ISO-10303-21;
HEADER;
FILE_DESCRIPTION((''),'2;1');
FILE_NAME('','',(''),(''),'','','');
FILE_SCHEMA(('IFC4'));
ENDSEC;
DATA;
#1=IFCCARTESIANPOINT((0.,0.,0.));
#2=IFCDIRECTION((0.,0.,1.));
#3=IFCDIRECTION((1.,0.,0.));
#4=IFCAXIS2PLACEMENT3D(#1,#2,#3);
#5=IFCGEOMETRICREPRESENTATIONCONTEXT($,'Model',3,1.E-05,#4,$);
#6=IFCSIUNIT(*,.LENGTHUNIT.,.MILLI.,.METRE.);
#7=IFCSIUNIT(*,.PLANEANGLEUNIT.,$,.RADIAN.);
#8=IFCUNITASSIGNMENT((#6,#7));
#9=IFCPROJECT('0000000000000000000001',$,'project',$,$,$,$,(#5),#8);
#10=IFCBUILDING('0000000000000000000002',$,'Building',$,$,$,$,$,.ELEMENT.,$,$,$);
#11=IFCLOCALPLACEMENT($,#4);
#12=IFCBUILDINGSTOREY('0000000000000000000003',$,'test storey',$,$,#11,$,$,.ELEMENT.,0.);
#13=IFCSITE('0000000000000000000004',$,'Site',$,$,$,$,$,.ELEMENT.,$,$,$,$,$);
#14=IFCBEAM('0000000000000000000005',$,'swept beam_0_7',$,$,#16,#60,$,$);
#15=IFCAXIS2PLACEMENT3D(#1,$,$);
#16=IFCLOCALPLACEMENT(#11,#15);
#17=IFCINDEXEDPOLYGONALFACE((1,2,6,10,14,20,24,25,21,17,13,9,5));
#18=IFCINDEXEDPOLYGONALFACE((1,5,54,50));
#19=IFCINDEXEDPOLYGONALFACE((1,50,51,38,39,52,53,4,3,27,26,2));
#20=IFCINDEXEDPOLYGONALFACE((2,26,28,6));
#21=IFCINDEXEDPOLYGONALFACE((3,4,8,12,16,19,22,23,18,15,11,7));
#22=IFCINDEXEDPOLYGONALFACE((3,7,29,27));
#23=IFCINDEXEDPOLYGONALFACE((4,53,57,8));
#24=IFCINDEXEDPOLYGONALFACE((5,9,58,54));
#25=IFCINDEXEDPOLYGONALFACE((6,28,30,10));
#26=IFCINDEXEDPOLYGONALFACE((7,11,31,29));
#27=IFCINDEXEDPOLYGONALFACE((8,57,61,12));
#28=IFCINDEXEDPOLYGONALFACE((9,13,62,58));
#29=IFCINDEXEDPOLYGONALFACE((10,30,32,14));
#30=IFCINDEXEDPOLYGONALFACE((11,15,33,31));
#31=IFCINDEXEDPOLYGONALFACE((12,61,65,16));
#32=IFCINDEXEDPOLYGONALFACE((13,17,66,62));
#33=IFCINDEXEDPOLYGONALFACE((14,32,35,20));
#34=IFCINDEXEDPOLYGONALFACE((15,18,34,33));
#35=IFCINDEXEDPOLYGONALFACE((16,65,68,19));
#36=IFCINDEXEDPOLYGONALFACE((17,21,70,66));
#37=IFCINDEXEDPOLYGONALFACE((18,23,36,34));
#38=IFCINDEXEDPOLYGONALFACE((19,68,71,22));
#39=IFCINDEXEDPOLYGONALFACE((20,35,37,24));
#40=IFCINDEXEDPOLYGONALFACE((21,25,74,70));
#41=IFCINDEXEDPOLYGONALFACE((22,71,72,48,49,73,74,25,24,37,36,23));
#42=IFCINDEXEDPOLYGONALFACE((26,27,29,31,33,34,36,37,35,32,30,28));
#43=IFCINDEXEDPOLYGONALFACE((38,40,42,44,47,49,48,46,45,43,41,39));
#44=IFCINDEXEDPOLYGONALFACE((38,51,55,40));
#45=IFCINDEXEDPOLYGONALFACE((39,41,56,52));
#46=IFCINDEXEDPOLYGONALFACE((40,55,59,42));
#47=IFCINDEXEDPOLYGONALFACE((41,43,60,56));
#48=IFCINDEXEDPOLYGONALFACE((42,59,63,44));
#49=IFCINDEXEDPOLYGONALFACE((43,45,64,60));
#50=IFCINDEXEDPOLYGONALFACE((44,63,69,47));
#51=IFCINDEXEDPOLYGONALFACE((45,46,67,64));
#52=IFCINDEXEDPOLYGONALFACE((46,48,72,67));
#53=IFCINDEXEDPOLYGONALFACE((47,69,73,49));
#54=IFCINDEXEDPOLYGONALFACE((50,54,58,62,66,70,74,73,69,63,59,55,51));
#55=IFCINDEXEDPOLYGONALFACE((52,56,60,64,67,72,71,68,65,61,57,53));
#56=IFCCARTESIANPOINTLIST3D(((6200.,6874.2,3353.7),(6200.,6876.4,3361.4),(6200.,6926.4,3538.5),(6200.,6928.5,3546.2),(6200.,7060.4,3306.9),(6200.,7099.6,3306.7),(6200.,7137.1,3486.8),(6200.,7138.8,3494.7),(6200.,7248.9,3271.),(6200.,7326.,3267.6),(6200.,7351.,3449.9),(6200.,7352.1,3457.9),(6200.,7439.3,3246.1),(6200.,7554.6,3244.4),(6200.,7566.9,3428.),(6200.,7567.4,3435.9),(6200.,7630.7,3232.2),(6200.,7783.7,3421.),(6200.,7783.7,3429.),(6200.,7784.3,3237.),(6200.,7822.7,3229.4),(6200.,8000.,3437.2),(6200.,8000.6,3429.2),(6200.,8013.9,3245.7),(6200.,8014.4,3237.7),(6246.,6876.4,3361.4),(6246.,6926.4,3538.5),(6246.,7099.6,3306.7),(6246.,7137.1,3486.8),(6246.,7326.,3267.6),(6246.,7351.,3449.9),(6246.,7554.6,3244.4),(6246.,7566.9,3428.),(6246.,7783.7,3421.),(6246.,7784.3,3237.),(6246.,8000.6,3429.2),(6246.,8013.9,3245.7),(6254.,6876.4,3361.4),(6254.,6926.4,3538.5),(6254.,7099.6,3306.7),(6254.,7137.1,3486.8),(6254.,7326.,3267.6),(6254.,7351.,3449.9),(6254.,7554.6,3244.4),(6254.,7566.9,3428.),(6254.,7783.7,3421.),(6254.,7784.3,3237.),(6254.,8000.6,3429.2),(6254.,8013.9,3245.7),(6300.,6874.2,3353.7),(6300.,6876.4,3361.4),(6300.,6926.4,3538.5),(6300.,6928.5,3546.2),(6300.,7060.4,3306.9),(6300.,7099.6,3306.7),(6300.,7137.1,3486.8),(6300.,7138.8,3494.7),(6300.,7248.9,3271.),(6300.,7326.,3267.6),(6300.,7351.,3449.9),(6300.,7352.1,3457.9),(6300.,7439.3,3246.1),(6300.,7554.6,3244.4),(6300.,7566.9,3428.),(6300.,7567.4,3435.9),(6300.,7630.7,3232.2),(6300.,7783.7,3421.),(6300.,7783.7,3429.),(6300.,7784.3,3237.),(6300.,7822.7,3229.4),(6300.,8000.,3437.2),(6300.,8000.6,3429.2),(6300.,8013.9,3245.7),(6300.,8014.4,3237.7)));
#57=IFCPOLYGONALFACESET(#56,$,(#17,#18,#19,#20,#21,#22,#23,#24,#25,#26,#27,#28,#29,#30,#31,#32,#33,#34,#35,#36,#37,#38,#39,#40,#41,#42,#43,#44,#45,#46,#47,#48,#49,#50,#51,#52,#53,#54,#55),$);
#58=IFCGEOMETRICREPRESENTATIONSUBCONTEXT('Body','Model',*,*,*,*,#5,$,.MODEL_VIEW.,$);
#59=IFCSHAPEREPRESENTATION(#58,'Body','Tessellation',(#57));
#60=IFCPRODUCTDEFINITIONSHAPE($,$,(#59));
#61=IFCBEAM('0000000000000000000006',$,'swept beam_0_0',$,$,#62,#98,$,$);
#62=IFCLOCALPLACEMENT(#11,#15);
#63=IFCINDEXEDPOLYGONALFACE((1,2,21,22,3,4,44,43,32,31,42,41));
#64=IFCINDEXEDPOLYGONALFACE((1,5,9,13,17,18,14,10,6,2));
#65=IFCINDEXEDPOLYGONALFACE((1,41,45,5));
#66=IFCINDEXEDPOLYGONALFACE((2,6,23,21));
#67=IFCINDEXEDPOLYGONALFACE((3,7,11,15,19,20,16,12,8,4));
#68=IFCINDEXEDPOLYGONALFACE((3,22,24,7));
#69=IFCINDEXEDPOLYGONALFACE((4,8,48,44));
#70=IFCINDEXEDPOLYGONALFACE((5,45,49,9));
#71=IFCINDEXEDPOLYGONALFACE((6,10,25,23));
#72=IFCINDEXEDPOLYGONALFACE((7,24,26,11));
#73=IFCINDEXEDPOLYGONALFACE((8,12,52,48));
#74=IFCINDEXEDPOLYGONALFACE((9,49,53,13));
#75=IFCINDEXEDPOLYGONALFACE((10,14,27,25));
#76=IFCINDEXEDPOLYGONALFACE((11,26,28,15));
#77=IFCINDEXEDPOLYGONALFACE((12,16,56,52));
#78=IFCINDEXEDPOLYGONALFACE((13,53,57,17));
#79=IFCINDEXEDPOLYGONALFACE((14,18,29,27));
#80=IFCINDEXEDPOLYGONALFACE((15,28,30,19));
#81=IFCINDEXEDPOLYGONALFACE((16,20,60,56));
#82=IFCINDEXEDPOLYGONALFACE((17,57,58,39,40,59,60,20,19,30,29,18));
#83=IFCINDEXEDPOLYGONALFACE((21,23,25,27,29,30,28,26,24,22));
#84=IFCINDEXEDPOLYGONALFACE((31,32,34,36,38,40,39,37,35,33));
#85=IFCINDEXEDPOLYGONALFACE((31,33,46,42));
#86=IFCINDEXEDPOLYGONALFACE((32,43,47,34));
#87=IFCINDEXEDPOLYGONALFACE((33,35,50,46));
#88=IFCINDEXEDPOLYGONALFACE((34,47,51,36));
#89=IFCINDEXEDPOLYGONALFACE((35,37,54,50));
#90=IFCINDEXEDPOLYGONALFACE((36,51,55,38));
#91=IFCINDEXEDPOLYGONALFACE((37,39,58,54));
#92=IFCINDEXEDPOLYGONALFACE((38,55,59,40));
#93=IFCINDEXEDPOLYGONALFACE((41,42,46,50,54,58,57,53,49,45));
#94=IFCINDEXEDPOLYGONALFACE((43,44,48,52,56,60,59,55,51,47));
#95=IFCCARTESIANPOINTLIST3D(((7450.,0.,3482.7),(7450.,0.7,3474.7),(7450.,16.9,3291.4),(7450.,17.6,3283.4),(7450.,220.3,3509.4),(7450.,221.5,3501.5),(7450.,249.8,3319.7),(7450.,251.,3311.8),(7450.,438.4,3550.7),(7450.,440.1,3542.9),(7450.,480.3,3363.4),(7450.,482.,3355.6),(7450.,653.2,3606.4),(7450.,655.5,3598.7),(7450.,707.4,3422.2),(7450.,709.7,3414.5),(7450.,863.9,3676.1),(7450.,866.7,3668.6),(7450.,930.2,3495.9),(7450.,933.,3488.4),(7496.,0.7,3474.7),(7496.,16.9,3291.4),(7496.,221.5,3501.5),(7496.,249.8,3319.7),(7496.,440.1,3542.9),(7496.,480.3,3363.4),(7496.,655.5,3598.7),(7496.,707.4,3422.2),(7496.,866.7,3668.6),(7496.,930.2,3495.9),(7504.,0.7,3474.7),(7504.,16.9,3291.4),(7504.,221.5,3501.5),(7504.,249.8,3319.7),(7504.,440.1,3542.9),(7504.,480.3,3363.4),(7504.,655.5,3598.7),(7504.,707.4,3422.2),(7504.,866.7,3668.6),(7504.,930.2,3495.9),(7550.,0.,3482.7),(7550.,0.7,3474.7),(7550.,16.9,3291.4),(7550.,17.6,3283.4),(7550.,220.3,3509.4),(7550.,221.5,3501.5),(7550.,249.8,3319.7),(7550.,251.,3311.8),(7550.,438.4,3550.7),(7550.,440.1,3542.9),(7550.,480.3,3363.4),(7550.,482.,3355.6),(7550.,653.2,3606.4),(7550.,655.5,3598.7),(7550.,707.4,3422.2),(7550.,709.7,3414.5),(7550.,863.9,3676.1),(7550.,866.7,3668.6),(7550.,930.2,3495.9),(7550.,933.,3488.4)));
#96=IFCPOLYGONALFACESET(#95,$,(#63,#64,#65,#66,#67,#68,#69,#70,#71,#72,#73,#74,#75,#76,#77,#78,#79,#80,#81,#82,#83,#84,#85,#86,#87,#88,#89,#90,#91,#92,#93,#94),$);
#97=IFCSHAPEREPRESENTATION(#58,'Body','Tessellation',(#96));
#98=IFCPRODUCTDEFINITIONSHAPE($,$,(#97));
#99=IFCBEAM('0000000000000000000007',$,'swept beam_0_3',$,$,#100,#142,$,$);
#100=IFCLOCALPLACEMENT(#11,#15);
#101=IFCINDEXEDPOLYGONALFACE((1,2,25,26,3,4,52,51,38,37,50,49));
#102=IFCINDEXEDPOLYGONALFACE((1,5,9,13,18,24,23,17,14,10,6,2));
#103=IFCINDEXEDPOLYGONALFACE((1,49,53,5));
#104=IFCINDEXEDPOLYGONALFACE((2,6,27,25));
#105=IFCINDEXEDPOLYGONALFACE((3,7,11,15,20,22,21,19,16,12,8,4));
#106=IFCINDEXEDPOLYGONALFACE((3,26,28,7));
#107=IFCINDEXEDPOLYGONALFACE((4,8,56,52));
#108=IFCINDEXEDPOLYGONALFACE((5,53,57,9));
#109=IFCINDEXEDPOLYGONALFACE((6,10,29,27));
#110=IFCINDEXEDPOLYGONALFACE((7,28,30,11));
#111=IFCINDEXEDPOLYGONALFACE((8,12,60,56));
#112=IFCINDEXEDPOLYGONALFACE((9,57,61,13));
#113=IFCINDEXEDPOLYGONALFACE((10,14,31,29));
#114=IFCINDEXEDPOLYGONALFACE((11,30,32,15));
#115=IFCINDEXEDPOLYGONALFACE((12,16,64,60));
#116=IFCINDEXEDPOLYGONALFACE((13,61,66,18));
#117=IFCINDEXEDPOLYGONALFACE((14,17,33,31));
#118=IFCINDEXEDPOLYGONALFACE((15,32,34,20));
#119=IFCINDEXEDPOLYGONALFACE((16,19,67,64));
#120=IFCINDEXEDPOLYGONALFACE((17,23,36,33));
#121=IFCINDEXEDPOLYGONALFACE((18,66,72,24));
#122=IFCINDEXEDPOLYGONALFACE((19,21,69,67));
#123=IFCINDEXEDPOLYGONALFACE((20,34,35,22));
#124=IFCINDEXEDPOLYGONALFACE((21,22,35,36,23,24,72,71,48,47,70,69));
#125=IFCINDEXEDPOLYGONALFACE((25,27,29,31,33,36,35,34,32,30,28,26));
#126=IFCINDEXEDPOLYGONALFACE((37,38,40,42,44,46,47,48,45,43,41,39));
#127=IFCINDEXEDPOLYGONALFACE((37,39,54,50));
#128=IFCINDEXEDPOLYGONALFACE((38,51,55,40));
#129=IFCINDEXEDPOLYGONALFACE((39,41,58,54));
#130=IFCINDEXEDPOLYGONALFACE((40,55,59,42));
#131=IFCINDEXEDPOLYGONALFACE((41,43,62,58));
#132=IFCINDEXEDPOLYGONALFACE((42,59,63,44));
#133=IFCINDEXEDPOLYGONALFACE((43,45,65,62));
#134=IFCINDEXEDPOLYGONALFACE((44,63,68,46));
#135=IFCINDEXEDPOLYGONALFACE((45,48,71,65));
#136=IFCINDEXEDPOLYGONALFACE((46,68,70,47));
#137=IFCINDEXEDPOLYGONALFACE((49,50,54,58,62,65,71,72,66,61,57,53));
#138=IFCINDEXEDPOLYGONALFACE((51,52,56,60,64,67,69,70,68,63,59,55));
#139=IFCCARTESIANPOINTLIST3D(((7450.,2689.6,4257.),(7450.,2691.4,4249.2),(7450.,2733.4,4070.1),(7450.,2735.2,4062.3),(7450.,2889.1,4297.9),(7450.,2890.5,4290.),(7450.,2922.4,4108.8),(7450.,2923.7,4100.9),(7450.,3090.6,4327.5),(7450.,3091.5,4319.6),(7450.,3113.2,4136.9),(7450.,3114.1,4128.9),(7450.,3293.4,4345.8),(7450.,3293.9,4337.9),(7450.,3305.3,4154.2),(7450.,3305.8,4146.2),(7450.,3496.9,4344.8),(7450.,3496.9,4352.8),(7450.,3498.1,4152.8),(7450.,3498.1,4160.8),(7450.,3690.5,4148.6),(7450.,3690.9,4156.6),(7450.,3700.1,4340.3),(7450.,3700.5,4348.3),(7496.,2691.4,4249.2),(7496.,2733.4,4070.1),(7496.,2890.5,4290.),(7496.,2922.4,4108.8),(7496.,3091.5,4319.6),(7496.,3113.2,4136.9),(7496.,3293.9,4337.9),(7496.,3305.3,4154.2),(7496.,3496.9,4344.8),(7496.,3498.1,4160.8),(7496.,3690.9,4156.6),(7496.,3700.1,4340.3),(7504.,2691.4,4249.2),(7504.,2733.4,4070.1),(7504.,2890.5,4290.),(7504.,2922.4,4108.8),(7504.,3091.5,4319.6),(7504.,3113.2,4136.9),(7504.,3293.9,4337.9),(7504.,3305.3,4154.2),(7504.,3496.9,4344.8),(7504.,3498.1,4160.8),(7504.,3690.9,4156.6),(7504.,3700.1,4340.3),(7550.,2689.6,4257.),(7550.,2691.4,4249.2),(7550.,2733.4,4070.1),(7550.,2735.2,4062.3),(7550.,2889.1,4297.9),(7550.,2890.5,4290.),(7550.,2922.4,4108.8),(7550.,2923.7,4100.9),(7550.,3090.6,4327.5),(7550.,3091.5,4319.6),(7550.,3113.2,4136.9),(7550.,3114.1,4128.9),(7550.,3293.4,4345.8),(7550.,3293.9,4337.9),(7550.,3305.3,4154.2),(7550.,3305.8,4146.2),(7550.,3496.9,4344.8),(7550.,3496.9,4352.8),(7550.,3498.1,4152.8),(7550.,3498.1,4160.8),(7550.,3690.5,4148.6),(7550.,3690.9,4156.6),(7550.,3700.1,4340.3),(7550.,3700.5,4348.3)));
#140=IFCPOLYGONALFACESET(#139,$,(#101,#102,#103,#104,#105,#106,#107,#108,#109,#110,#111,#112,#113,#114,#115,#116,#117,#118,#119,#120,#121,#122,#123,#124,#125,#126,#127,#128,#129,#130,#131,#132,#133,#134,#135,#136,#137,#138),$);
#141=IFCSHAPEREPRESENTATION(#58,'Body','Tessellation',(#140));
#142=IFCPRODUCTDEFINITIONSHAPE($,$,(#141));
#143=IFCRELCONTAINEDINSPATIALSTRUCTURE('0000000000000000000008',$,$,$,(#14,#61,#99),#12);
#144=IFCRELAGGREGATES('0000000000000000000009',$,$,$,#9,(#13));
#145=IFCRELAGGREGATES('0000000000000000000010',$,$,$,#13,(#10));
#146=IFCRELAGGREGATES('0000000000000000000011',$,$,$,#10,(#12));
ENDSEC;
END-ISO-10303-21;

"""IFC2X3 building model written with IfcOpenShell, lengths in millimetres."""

from ifc_helpers import new_model, entity, si_unit, origin_with_axes, place, context, subcontext, project, spatial, element, save


model = new_model("IFC2X3")

# Units and contexts
model_context = context("Model", 3, precision=1e-05, world=origin_with_axes())
body_context = subcontext(model_context, "Body", "Model", "MODEL_VIEW")
ifc_project = project(units=[si_unit("LENGTHUNIT", "METRE", prefix="MILLI"), si_unit("PLANEANGLEUNIT", "RADIAN")], contexts=[model_context])

# Site, building, storey
site = spatial("IfcSite", under=ifc_project, Name="Site", CompositionType="ELEMENT")
building = spatial("IfcBuilding", under=site, Name="Building", CompositionType="ELEMENT")
storey_placement = place(None, origin_with_axes())
storey = spatial("IfcBuildingStorey", under=building, at=storey_placement, Name="test storey", CompositionType="ELEMENT", Elevation=0.0)

# Beams
beam_1_placement = place(storey_placement, origin_with_axes())
element("IfcBeam", 1, at=beam_1_placement, inside=storey, Name="swept beam_0_7", context=body_context, shape_type="SweptSolid", body=[
    entity("IfcRevolvedAreaSolid", entity("IfcArbitraryClosedProfileDef", "AREA", None, entity("IfcPolyline", [entity("IfcCartesianPoint", [192.0, 50.0]), entity("IfcCartesianPoint", [192.0, 4.0]), entity("IfcCartesianPoint", [8.0, 4.0]), entity("IfcCartesianPoint", [8.0, 50.0]), entity("IfcCartesianPoint", [0.0, 50.0]), entity("IfcCartesianPoint", [0.0, -50.0]), entity("IfcCartesianPoint", [8.0, -50.0]), entity("IfcCartesianPoint", [8.0, -4.0]), entity("IfcCartesianPoint", [192.0, -4.0]), entity("IfcCartesianPoint", [192.0, -50.0]), entity("IfcCartesianPoint", [200.0, -50.0]), entity("IfcCartesianPoint", [200.0, 50.0]), entity("IfcCartesianPoint", [192.0, 50.0])])), entity("IfcAxis2Placement3D", entity("IfcCartesianPoint", [6250.0, 6928.5, 3546.2]), entity("IfcDirection", [0.0, -0.9624, 0.2717]), entity("IfcDirection", [0.0, -0.2717, -0.9624])), entity("IfcAxis1Placement", entity("IfcCartesianPoint", [-3115.5, 0.0, 0.0]), entity("IfcDirection", [0.0, 1.0, 0.0])), 0.347435),
])
beam_2_placement = place(storey_placement, origin_with_axes())
element("IfcBeam", 2, at=beam_2_placement, inside=storey, Name="swept beam_0_0", context=body_context, shape_type="SweptSolid", body=[
    entity("IfcRevolvedAreaSolid", entity("IfcArbitraryClosedProfileDef", "AREA", None, entity("IfcPolyline", [entity("IfcCartesianPoint", [192.0, 50.0]), entity("IfcCartesianPoint", [192.0, 4.0]), entity("IfcCartesianPoint", [8.0, 4.0]), entity("IfcCartesianPoint", [8.0, 50.0]), entity("IfcCartesianPoint", [0.0, 50.0]), entity("IfcCartesianPoint", [0.0, -50.0]), entity("IfcCartesianPoint", [8.0, -50.0]), entity("IfcCartesianPoint", [8.0, -4.0]), entity("IfcCartesianPoint", [192.0, -4.0]), entity("IfcCartesianPoint", [192.0, -50.0]), entity("IfcCartesianPoint", [200.0, -50.0]), entity("IfcCartesianPoint", [200.0, 50.0]), entity("IfcCartesianPoint", [192.0, 50.0])])), entity("IfcAxis2Placement3D", entity("IfcCartesianPoint", [7500.0, 0.0, 3482.7]), entity("IfcDirection", [0.0, -0.9961, -0.0878]), entity("IfcDirection", [0.0, 0.0878, -0.9961])), entity("IfcAxis1Placement", entity("IfcCartesianPoint", [-3354.7, 0.0, 0.0]), entity("IfcDirection", [0.0, 1.0, 0.0])), 0.264664),
])
beam_3_placement = place(storey_placement, origin_with_axes())
element("IfcBeam", 3, at=beam_3_placement, inside=storey, Name="swept beam_0_3", context=body_context, shape_type="SweptSolid", body=[
    entity("IfcRevolvedAreaSolid", entity("IfcArbitraryClosedProfileDef", "AREA", None, entity("IfcPolyline", [entity("IfcCartesianPoint", [-192.0, -50.0]), entity("IfcCartesianPoint", [-192.0, -4.0]), entity("IfcCartesianPoint", [-8.0, -4.0]), entity("IfcCartesianPoint", [-8.0, -50.0]), entity("IfcCartesianPoint", [0.0, -50.0]), entity("IfcCartesianPoint", [0.0, 50.0]), entity("IfcCartesianPoint", [-8.0, 50.0]), entity("IfcCartesianPoint", [-8.0, 4.0]), entity("IfcCartesianPoint", [-192.0, 4.0]), entity("IfcCartesianPoint", [-192.0, 50.0]), entity("IfcCartesianPoint", [-200.0, 50.0]), entity("IfcCartesianPoint", [-200.0, -50.0]), entity("IfcCartesianPoint", [-192.0, -50.0])])), entity("IfcAxis2Placement3D", entity("IfcCartesianPoint", [7500.0, 2689.6, 4257.0]), entity("IfcDirection", [0.0, -0.9736, -0.2281]), entity("IfcDirection", [0.0, -0.2281, 0.9736])), entity("IfcAxis1Placement", entity("IfcCartesianPoint", [-3635.9, 0.0, 0.0]), entity("IfcDirection", [0.0, 1.0, 0.0])), 0.280071),
])

save(model, "model.ifc")
